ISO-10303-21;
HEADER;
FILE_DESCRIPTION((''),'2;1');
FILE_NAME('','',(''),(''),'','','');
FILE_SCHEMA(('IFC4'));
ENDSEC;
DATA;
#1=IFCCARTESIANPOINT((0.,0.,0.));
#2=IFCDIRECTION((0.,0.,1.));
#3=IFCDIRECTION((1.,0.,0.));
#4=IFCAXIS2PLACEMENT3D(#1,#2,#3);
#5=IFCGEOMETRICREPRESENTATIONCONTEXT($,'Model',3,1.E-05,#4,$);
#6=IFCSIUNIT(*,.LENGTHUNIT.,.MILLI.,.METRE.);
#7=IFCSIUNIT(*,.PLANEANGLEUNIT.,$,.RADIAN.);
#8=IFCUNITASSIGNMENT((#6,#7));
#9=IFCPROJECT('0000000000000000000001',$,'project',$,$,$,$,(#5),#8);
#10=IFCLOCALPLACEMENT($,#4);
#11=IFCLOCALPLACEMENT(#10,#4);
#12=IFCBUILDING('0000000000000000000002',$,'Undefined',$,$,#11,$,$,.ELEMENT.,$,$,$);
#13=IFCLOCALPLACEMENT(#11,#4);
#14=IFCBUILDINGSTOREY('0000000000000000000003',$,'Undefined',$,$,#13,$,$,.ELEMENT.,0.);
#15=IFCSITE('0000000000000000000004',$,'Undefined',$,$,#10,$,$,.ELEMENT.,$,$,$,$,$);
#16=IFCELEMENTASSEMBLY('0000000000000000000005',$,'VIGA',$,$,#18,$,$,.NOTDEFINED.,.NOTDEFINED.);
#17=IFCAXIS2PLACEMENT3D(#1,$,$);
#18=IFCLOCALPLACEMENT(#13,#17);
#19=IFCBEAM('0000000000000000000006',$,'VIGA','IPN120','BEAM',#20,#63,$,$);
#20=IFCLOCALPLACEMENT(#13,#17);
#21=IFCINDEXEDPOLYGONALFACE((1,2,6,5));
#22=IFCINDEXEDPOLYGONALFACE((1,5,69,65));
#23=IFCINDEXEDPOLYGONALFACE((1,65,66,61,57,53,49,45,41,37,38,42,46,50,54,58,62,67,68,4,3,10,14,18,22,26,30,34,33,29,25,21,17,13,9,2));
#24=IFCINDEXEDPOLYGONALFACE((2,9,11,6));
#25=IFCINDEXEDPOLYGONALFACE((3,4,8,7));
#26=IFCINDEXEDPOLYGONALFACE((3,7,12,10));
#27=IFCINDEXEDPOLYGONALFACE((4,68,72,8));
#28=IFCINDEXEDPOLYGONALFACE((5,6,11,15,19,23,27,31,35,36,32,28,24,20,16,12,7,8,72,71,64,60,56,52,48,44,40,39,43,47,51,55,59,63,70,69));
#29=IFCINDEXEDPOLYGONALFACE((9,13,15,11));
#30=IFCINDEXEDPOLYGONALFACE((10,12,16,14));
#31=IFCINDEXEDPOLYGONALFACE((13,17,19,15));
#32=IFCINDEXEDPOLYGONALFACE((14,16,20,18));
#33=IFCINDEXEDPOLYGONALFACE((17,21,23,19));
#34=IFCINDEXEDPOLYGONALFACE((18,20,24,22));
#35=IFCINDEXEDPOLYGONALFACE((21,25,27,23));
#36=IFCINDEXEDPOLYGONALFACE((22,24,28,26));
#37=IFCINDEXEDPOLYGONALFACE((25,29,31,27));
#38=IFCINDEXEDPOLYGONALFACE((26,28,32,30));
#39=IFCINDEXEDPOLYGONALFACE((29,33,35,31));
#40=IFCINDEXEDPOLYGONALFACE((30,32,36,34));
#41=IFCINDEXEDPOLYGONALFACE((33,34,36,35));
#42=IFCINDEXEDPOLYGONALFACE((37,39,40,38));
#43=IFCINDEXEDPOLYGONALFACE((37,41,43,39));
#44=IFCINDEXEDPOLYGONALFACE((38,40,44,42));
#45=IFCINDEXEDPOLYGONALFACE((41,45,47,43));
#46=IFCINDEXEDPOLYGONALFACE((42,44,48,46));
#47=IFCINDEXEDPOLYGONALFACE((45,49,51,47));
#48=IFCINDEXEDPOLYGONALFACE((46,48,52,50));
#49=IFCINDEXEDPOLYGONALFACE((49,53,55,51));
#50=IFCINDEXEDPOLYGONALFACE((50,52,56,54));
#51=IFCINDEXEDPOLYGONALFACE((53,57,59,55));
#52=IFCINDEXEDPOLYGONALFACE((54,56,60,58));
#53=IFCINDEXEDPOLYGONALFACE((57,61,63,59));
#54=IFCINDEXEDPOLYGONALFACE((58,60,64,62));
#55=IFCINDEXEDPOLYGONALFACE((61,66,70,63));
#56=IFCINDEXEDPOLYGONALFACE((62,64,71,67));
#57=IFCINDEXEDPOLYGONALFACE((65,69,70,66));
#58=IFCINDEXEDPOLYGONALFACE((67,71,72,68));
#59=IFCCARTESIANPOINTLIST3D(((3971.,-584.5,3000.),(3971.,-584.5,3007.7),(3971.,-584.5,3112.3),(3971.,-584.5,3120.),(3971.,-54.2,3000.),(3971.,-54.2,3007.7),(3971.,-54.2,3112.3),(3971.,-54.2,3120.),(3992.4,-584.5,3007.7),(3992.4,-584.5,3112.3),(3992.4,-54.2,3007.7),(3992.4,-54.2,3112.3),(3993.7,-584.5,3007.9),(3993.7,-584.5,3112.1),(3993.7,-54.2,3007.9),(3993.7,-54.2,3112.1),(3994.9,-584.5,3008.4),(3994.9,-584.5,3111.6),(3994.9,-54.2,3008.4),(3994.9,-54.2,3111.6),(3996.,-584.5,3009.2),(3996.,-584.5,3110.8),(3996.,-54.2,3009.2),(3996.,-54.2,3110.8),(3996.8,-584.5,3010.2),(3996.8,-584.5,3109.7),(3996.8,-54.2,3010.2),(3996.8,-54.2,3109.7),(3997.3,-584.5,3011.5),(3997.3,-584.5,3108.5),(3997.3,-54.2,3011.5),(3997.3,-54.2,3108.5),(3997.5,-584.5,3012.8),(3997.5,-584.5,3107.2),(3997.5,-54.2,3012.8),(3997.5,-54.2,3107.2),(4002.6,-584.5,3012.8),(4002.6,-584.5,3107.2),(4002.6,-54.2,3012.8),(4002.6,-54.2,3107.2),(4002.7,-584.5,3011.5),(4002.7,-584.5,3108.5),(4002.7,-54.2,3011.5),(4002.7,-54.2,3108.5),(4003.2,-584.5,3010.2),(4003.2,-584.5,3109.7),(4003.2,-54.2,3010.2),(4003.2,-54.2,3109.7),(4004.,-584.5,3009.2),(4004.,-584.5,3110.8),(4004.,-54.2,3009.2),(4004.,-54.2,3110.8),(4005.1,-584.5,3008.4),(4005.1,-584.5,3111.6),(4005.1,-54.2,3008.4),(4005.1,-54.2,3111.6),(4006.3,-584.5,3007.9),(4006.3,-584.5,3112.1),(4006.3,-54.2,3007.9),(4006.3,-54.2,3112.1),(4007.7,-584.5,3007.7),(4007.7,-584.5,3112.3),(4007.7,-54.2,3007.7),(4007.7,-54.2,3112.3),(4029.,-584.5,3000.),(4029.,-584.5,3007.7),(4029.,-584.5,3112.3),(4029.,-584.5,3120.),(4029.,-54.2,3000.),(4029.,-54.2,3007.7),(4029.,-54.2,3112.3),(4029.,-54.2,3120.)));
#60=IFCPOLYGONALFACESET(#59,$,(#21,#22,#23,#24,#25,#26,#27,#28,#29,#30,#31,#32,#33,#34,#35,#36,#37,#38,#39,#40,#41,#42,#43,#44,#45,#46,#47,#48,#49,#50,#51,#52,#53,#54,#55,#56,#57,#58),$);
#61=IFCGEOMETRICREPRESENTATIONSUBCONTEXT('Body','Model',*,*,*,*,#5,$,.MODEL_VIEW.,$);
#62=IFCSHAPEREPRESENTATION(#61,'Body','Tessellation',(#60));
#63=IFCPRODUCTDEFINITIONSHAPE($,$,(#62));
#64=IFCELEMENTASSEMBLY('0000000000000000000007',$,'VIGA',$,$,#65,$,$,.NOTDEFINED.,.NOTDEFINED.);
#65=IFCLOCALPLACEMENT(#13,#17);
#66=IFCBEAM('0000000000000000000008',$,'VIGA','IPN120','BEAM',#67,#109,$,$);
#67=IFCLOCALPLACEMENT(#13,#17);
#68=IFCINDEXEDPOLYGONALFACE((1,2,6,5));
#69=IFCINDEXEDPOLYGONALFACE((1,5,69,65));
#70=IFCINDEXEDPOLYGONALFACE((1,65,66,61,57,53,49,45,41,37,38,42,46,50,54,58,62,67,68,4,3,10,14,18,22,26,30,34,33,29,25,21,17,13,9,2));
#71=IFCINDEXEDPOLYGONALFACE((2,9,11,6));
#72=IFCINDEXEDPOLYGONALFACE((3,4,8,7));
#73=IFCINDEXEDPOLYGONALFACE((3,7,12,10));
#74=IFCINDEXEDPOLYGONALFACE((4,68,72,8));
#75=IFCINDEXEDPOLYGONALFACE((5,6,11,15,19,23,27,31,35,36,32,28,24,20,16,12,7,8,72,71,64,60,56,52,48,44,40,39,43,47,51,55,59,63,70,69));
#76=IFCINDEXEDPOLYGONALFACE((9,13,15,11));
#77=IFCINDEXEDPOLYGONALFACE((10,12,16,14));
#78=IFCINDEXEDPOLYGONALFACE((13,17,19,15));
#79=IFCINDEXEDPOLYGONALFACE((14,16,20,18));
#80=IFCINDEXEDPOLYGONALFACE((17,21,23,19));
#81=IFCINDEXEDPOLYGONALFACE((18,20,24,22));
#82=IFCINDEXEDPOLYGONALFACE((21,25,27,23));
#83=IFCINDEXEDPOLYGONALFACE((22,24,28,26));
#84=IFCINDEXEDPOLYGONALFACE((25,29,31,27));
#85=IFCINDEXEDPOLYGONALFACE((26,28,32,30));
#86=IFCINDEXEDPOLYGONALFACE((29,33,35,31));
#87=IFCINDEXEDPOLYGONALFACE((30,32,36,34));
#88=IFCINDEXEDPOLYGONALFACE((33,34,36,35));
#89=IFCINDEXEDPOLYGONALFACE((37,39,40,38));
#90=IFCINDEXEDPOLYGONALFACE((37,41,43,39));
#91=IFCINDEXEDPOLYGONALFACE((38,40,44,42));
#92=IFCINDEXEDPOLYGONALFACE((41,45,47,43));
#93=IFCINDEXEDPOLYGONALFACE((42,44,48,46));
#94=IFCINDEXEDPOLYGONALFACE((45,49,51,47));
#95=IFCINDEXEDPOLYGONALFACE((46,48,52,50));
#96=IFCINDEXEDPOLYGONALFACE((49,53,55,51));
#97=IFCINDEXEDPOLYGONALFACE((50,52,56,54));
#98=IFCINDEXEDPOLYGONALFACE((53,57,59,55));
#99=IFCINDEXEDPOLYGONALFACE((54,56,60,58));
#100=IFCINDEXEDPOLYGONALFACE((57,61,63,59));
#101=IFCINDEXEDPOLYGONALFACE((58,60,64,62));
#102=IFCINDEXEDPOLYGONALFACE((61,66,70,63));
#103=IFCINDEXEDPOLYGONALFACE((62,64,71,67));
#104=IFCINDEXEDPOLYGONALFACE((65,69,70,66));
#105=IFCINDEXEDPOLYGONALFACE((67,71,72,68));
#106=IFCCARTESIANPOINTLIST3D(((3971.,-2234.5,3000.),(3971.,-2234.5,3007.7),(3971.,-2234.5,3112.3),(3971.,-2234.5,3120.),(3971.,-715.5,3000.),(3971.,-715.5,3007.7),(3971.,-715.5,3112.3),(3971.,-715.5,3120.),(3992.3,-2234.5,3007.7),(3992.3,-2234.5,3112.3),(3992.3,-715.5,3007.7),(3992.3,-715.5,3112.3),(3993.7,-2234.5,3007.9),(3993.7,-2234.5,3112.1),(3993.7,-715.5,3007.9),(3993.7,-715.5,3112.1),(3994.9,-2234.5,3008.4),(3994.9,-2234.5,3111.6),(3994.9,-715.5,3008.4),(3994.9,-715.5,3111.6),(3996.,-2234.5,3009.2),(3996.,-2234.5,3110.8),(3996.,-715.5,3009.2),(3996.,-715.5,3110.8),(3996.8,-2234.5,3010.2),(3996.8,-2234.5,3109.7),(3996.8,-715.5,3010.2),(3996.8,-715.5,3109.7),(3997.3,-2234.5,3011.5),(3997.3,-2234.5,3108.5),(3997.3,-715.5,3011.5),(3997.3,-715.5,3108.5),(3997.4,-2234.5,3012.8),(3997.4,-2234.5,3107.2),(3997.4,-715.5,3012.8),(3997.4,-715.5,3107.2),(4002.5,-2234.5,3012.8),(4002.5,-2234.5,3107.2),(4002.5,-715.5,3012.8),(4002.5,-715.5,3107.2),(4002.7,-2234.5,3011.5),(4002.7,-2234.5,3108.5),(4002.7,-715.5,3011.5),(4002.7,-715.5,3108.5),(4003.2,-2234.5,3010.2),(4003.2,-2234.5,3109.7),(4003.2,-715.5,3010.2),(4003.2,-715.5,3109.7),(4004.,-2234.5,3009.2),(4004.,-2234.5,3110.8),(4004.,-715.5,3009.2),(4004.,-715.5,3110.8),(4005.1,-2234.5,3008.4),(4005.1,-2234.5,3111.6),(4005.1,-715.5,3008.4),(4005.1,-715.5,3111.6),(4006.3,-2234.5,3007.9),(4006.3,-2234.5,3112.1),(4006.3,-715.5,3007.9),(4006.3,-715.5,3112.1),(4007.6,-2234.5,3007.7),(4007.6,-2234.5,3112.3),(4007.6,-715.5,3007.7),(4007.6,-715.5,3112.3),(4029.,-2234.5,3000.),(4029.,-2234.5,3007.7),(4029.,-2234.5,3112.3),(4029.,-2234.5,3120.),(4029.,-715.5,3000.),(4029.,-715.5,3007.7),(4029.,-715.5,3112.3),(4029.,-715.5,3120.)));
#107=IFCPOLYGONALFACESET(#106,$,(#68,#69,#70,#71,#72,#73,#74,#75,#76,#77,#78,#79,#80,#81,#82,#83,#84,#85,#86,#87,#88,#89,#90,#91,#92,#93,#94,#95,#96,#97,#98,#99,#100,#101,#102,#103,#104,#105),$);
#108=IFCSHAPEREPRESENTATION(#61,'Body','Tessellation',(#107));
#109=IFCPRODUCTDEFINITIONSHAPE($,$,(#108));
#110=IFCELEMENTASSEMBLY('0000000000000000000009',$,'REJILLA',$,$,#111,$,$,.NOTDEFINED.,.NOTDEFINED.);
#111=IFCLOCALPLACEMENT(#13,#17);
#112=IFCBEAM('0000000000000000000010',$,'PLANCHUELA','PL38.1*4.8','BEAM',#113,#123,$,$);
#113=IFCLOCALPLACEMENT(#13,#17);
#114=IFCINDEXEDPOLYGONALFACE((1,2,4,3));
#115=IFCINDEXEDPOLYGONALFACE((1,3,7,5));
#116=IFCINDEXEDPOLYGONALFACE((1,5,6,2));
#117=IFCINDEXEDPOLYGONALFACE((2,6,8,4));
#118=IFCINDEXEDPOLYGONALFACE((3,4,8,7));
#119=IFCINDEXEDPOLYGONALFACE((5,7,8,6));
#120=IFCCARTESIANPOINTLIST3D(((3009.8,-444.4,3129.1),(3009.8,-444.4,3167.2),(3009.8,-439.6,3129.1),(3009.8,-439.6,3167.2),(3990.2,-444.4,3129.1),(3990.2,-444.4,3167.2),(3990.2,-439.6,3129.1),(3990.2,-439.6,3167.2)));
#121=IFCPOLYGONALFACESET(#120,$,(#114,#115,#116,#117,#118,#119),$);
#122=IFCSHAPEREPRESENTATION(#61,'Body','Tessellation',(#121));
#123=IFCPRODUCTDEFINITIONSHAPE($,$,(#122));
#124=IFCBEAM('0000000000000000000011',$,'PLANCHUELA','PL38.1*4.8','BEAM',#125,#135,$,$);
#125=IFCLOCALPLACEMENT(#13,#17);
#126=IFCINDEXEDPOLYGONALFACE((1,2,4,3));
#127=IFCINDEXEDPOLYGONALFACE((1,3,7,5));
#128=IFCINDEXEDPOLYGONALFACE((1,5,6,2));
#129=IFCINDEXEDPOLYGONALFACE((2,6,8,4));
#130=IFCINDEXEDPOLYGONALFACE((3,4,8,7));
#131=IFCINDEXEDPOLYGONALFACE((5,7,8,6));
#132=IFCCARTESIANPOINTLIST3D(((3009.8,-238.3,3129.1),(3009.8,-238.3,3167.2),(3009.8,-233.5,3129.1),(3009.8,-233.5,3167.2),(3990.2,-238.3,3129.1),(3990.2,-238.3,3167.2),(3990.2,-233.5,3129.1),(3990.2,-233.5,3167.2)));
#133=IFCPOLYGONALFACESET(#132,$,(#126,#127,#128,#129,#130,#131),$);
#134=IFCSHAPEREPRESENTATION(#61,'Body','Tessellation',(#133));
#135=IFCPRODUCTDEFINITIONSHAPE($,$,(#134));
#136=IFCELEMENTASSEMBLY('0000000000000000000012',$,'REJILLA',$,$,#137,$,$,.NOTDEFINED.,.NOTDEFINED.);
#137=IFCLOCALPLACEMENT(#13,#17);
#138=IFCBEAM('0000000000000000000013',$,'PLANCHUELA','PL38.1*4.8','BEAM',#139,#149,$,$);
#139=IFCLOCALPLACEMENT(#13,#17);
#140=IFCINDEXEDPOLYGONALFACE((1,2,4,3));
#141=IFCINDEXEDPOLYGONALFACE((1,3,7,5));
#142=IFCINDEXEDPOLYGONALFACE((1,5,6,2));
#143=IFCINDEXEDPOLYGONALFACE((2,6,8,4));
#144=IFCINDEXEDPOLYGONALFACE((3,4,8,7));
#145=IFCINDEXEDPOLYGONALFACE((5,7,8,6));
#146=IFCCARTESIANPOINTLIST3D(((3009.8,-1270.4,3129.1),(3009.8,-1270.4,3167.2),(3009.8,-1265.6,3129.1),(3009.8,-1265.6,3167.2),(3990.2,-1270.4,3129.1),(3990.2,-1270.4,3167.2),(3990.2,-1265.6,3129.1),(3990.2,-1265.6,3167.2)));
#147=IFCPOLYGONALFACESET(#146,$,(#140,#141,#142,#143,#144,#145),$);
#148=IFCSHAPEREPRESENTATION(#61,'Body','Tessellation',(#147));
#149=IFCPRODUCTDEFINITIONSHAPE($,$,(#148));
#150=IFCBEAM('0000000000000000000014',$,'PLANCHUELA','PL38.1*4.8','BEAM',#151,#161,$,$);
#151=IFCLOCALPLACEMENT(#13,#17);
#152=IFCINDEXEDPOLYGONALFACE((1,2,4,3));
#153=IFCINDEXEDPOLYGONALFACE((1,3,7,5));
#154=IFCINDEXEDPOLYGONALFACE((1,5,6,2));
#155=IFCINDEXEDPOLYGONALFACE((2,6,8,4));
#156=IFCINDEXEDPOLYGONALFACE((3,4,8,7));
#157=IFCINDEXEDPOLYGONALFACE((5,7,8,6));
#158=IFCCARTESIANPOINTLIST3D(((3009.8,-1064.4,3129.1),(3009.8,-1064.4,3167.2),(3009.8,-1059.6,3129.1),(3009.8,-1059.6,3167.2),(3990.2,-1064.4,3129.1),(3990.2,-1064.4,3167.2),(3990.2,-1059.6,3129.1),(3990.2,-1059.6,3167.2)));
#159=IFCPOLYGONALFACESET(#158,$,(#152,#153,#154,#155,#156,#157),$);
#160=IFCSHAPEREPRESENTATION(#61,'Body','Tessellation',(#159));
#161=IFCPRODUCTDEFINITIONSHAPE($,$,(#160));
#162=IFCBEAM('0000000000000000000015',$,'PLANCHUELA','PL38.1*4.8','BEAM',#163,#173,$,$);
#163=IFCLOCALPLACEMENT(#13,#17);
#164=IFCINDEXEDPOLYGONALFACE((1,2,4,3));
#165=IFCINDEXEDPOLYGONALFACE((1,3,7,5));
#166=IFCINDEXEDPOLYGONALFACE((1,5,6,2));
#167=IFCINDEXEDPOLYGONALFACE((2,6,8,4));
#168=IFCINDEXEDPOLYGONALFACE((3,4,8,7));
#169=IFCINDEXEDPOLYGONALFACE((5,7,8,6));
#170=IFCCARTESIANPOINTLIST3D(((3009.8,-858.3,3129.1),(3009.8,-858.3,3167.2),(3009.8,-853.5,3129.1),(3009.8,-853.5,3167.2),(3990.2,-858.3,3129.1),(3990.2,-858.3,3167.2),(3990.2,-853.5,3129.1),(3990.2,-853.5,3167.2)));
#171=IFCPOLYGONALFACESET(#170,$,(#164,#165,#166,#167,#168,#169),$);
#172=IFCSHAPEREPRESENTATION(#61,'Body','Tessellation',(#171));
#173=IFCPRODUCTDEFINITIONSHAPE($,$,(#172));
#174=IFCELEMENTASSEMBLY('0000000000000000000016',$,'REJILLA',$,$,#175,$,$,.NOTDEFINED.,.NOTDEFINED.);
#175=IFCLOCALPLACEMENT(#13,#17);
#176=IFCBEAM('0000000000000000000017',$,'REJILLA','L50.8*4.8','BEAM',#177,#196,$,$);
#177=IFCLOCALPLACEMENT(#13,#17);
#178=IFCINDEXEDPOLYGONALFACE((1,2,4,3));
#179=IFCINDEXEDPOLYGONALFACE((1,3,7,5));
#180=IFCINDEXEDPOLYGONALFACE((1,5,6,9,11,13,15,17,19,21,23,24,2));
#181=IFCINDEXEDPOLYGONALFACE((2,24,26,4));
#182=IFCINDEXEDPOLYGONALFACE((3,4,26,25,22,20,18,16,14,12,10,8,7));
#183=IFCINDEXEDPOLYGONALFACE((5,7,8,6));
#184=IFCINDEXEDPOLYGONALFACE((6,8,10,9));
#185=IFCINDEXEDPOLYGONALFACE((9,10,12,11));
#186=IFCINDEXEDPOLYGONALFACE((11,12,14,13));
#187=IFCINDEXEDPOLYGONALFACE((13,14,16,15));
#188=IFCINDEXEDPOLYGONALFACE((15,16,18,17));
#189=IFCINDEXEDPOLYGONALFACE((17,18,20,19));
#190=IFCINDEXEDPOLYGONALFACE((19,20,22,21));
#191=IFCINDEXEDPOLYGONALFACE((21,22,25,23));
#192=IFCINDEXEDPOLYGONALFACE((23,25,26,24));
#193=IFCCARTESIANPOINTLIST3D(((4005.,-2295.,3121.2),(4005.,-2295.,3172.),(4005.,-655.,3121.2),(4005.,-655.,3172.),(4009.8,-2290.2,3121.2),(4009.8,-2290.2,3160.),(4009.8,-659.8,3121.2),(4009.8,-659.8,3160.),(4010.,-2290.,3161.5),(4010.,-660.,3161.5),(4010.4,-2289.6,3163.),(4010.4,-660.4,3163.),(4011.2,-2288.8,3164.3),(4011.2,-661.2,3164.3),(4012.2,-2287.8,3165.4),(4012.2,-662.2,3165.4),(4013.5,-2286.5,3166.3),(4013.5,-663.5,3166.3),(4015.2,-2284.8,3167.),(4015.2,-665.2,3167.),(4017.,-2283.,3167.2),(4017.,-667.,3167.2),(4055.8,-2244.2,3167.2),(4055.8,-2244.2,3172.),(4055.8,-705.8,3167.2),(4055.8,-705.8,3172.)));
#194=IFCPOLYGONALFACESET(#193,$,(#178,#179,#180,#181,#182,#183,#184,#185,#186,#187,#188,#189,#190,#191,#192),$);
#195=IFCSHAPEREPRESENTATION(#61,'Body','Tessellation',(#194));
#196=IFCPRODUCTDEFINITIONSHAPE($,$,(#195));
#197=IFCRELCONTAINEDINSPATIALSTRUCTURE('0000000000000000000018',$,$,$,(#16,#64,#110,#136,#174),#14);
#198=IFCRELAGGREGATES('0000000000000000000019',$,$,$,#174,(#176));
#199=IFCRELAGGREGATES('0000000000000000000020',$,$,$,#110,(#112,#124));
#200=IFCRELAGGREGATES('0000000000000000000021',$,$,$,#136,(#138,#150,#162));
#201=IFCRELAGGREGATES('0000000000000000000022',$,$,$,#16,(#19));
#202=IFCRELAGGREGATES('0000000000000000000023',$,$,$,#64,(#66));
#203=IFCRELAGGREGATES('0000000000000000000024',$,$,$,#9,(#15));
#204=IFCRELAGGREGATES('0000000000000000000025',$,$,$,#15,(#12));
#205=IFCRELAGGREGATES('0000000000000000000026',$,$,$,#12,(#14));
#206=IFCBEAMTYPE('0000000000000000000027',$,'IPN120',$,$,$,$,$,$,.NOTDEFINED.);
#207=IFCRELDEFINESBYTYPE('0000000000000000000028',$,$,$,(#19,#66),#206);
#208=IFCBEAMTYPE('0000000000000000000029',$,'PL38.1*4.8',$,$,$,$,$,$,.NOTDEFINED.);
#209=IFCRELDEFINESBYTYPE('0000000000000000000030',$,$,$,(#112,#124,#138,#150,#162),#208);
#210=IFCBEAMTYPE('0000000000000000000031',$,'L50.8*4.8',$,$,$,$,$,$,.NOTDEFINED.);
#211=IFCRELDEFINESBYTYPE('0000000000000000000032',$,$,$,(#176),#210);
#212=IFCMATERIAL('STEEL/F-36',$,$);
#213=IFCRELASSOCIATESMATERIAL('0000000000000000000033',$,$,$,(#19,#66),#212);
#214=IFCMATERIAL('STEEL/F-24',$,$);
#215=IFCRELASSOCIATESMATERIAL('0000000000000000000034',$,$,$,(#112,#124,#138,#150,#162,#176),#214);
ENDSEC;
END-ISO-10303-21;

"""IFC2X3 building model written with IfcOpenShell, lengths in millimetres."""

from ifc_helpers import new_model, si_unit, frame, origin_with_axes, origin_2d_with_axis, place, context, subcontext, project, spatial, rectangle, i_section, l_section, extrude, clip, halfspace, material, type_object, element, aggregate, save


model = new_model("IFC2X3")

# Units and contexts
model_context = context("Model", 3, precision=1e-05, world=origin_with_axes())
body_context = subcontext(model_context, "Body", "Model", "MODEL_VIEW")
ifc_project = project(units=[si_unit("LENGTHUNIT", "METRE", prefix="MILLI"), si_unit("PLANEANGLEUNIT", "RADIAN")], contexts=[model_context])

# Site, building, storey
site_placement = place(None, origin_with_axes())
site = spatial("IfcSite", under=ifc_project, at=site_placement, Name="Undefined", CompositionType="ELEMENT")
building_placement = place(site_placement, origin_with_axes())
building = spatial("IfcBuilding", under=site, at=building_placement, Name="Undefined", CompositionType="ELEMENT")
storey_placement = place(building_placement, origin_with_axes())
storey = spatial("IfcBuildingStorey", under=building, at=storey_placement, Name="Undefined", CompositionType="ELEMENT", Elevation=0.0)

# Element assemblies, beams
assembly_1_placement = place(storey_placement, origin_with_axes())
assembly_1 = element("IfcElementAssembly", 1, at=assembly_1_placement, inside=storey, Name="VIGA", AssemblyPlace="NOTDEFINED", PredefinedType="NOTDEFINED")
ifc_material_1 = material(Name="STEEL/F-36")
beam_type_1 = type_object("IfcBeamType", Name="IPN120", PredefinedType="NOTDEFINED")
beam_1_placement = place(assembly_1_placement, frame((4000.0, -54.2, 3060.0), z_axis=(0.0, 0.0, 1.0), x_axis=(0.0, -1.0, 0.0)))
beam_1 = element("IfcBeam", 2, at=beam_1_placement, type_object=beam_type_1, material=ifc_material_1, Name="VIGA", Description="IPN120", ObjectType="BEAM", context=body_context, shape_type="SweptSolid", body=[
    extrude(i_section(OverallWidth=58.0, OverallDepth=120.0, WebThickness=5.1, FlangeThickness=7.7, FilletRadius=5.1, at=origin_2d_with_axis()), frame((530.3, 0.0, 0.0), z_axis=(-1.0, 0.0, 0.0), x_axis=(0.0, -1.0, 0.0)), (0.0, 0.0, 1.0), 530.3),
])
assembly_2_placement = place(storey_placement, origin_with_axes())
assembly_2 = element("IfcElementAssembly", 3, at=assembly_2_placement, inside=storey, Name="VIGA", AssemblyPlace="NOTDEFINED", PredefinedType="NOTDEFINED")
beam_2_placement = place(assembly_2_placement, frame((4000.0, -715.5, 3060.0), z_axis=(0.0, 0.0, 1.0), x_axis=(0.0, -1.0, 0.0)))
beam_2 = element("IfcBeam", 4, at=beam_2_placement, type_object=beam_type_1, material=ifc_material_1, Name="VIGA", Description="IPN120", ObjectType="BEAM", context=body_context, shape_type="SweptSolid", body=[
    extrude(i_section(OverallWidth=58.0, OverallDepth=120.0, WebThickness=5.1, FlangeThickness=7.7, FilletRadius=5.1, at=origin_2d_with_axis()), frame((1519.0, 0.0, 0.0), z_axis=(-1.0, 0.0, 0.0), x_axis=(0.0, -1.0, 0.0)), (0.0, 0.0, 1.0), 1519.0),
])

# Element assemblies, beams
assembly_3_placement = place(storey_placement, origin_with_axes())
assembly_3 = element("IfcElementAssembly", 5, at=assembly_3_placement, inside=storey, Name="REJILLA", AssemblyPlace="NOTDEFINED", PredefinedType="NOTDEFINED")
ifc_material_2 = material(Name="STEEL/F-24")
beam_type_2 = type_object("IfcBeamType", Name="PL38.1*4.8", PredefinedType="NOTDEFINED")
beam_3_placement = place(assembly_3_placement, frame((3990.2, -442.0, 3148.1), z_axis=(-0.000041, 0.0, -1.0), x_axis=(-1.0, 0.0, 0.000041)))
beam_3 = element("IfcBeam", 6, at=beam_3_placement, type_object=beam_type_2, material=ifc_material_2, Name="PLANCHUELA", Description="PL38.1*4.8", ObjectType="BEAM", context=body_context, shape_type="SweptSolid", body=[
    extrude(rectangle(XDim=4.8, YDim=38.1, at=origin_2d_with_axis()), frame((980.4, 0.0, 0.0), z_axis=(-1.0, 0.0, 0.0), x_axis=(0.0, -1.0, 0.0)), (0.0, 0.0, 1.0), 980.4),
])
beam_4_placement = place(assembly_3_placement, frame((3990.2, -235.9, 3148.1), z_axis=(-0.000041, 0.0, -1.0), x_axis=(-1.0, 0.0, 0.000041)))
beam_4 = element("IfcBeam", 7, at=beam_4_placement, type_object=beam_type_2, material=ifc_material_2, Name="PLANCHUELA", Description="PL38.1*4.8", ObjectType="BEAM", context=body_context, shape_type="SweptSolid", body=[
    extrude(rectangle(XDim=4.8, YDim=38.1, at=origin_2d_with_axis()), frame((980.4, 0.0, 0.0), z_axis=(-1.0, 0.0, 0.0), x_axis=(0.0, -1.0, 0.0)), (0.0, 0.0, 1.0), 980.4),
])
assembly_4_placement = place(storey_placement, origin_with_axes())
assembly_4 = element("IfcElementAssembly", 8, at=assembly_4_placement, inside=storey, Name="REJILLA", AssemblyPlace="NOTDEFINED", PredefinedType="NOTDEFINED")
beam_5_placement = place(assembly_4_placement, frame((3990.2, -1268.0, 3148.1), z_axis=(-0.000041, 0.0, -1.0), x_axis=(-1.0, 0.0, 0.000041)))
beam_5 = element("IfcBeam", 9, at=beam_5_placement, type_object=beam_type_2, material=ifc_material_2, Name="PLANCHUELA", Description="PL38.1*4.8", ObjectType="BEAM", context=body_context, shape_type="SweptSolid", body=[
    extrude(rectangle(XDim=4.8, YDim=38.1, at=origin_2d_with_axis()), frame((980.4, 0.0, 0.0), z_axis=(-1.0, 0.0, 0.0), x_axis=(0.0, -1.0, 0.0)), (0.0, 0.0, 1.0), 980.4),
])
beam_6_placement = place(assembly_4_placement, frame((3990.2, -1062.0, 3148.1), z_axis=(-0.000041, 0.0, -1.0), x_axis=(-1.0, 0.0, 0.000041)))
beam_6 = element("IfcBeam", 10, at=beam_6_placement, type_object=beam_type_2, material=ifc_material_2, Name="PLANCHUELA", Description="PL38.1*4.8", ObjectType="BEAM", context=body_context, shape_type="SweptSolid", body=[
    extrude(rectangle(XDim=4.8, YDim=38.1, at=origin_2d_with_axis()), frame((980.4, 0.0, 0.0), z_axis=(-1.0, 0.0, 0.0), x_axis=(0.0, -1.0, 0.0)), (0.0, 0.0, 1.0), 980.4),
])
beam_7_placement = place(assembly_4_placement, frame((3990.2, -855.9, 3148.1), z_axis=(-0.000041, 0.0, -1.0), x_axis=(-1.0, 0.0, 0.000041)))
beam_7 = element("IfcBeam", 11, at=beam_7_placement, type_object=beam_type_2, material=ifc_material_2, Name="PLANCHUELA", Description="PL38.1*4.8", ObjectType="BEAM", context=body_context, shape_type="SweptSolid", body=[
    extrude(rectangle(XDim=4.8, YDim=38.1, at=origin_2d_with_axis()), frame((980.4, 0.0, 0.0), z_axis=(-1.0, 0.0, 0.0), x_axis=(0.0, -1.0, 0.0)), (0.0, 0.0, 1.0), 980.4),
])

# Element assembly, beam
assembly_5_placement = place(storey_placement, origin_with_axes())
assembly_5 = element("IfcElementAssembly", 12, at=assembly_5_placement, inside=storey, Name="REJILLA", AssemblyPlace="NOTDEFINED", PredefinedType="NOTDEFINED")
beam_type_3 = type_object("IfcBeamType", Name="L50.8*4.8", PredefinedType="NOTDEFINED")
beam_8_placement = place(assembly_5_placement, frame((4030.4, -655.0, 3146.6), z_axis=(0.0, 0.0, -1.0), x_axis=(0.0, -1.0, 0.0)))
beam_8 = element("IfcBeam", 13, at=beam_8_placement, type_object=beam_type_3, material=ifc_material_2, Name="REJILLA", Description="L50.8*4.8", ObjectType="BEAM", context=body_context, shape_type="Clipping", body=[
    clip(clip(extrude(l_section(Depth=50.8, Width=50.8, Thickness=4.8, FilletRadius=7.2, at=origin_2d_with_axis()), frame((1665.9, 0.0, 0.0), z_axis=(-1.0, 0.0, 0.0), x_axis=(0.0, -1.0, 0.0)), (0.0, 0.0, 1.0), 1691.8), halfspace(frame((1589.2, -25.4, 0.0), z_axis=(-0.707107, 0.707107, 0.0), x_axis=(0.0, 0.0, -1.0)), True)), halfspace(frame((50.8, -25.4, 0.0), z_axis=(-0.707107, -0.707107, 0.0), x_axis=(0.0, 0.0, -1.0)), False)),
])
aggregate(assembly_5, [beam_8])

aggregate(assembly_3, [beam_3, beam_4])
aggregate(assembly_4, [beam_5, beam_6, beam_7])

aggregate(assembly_1, [beam_1])
aggregate(assembly_2, [beam_2])

save(model, "model.ifc")
